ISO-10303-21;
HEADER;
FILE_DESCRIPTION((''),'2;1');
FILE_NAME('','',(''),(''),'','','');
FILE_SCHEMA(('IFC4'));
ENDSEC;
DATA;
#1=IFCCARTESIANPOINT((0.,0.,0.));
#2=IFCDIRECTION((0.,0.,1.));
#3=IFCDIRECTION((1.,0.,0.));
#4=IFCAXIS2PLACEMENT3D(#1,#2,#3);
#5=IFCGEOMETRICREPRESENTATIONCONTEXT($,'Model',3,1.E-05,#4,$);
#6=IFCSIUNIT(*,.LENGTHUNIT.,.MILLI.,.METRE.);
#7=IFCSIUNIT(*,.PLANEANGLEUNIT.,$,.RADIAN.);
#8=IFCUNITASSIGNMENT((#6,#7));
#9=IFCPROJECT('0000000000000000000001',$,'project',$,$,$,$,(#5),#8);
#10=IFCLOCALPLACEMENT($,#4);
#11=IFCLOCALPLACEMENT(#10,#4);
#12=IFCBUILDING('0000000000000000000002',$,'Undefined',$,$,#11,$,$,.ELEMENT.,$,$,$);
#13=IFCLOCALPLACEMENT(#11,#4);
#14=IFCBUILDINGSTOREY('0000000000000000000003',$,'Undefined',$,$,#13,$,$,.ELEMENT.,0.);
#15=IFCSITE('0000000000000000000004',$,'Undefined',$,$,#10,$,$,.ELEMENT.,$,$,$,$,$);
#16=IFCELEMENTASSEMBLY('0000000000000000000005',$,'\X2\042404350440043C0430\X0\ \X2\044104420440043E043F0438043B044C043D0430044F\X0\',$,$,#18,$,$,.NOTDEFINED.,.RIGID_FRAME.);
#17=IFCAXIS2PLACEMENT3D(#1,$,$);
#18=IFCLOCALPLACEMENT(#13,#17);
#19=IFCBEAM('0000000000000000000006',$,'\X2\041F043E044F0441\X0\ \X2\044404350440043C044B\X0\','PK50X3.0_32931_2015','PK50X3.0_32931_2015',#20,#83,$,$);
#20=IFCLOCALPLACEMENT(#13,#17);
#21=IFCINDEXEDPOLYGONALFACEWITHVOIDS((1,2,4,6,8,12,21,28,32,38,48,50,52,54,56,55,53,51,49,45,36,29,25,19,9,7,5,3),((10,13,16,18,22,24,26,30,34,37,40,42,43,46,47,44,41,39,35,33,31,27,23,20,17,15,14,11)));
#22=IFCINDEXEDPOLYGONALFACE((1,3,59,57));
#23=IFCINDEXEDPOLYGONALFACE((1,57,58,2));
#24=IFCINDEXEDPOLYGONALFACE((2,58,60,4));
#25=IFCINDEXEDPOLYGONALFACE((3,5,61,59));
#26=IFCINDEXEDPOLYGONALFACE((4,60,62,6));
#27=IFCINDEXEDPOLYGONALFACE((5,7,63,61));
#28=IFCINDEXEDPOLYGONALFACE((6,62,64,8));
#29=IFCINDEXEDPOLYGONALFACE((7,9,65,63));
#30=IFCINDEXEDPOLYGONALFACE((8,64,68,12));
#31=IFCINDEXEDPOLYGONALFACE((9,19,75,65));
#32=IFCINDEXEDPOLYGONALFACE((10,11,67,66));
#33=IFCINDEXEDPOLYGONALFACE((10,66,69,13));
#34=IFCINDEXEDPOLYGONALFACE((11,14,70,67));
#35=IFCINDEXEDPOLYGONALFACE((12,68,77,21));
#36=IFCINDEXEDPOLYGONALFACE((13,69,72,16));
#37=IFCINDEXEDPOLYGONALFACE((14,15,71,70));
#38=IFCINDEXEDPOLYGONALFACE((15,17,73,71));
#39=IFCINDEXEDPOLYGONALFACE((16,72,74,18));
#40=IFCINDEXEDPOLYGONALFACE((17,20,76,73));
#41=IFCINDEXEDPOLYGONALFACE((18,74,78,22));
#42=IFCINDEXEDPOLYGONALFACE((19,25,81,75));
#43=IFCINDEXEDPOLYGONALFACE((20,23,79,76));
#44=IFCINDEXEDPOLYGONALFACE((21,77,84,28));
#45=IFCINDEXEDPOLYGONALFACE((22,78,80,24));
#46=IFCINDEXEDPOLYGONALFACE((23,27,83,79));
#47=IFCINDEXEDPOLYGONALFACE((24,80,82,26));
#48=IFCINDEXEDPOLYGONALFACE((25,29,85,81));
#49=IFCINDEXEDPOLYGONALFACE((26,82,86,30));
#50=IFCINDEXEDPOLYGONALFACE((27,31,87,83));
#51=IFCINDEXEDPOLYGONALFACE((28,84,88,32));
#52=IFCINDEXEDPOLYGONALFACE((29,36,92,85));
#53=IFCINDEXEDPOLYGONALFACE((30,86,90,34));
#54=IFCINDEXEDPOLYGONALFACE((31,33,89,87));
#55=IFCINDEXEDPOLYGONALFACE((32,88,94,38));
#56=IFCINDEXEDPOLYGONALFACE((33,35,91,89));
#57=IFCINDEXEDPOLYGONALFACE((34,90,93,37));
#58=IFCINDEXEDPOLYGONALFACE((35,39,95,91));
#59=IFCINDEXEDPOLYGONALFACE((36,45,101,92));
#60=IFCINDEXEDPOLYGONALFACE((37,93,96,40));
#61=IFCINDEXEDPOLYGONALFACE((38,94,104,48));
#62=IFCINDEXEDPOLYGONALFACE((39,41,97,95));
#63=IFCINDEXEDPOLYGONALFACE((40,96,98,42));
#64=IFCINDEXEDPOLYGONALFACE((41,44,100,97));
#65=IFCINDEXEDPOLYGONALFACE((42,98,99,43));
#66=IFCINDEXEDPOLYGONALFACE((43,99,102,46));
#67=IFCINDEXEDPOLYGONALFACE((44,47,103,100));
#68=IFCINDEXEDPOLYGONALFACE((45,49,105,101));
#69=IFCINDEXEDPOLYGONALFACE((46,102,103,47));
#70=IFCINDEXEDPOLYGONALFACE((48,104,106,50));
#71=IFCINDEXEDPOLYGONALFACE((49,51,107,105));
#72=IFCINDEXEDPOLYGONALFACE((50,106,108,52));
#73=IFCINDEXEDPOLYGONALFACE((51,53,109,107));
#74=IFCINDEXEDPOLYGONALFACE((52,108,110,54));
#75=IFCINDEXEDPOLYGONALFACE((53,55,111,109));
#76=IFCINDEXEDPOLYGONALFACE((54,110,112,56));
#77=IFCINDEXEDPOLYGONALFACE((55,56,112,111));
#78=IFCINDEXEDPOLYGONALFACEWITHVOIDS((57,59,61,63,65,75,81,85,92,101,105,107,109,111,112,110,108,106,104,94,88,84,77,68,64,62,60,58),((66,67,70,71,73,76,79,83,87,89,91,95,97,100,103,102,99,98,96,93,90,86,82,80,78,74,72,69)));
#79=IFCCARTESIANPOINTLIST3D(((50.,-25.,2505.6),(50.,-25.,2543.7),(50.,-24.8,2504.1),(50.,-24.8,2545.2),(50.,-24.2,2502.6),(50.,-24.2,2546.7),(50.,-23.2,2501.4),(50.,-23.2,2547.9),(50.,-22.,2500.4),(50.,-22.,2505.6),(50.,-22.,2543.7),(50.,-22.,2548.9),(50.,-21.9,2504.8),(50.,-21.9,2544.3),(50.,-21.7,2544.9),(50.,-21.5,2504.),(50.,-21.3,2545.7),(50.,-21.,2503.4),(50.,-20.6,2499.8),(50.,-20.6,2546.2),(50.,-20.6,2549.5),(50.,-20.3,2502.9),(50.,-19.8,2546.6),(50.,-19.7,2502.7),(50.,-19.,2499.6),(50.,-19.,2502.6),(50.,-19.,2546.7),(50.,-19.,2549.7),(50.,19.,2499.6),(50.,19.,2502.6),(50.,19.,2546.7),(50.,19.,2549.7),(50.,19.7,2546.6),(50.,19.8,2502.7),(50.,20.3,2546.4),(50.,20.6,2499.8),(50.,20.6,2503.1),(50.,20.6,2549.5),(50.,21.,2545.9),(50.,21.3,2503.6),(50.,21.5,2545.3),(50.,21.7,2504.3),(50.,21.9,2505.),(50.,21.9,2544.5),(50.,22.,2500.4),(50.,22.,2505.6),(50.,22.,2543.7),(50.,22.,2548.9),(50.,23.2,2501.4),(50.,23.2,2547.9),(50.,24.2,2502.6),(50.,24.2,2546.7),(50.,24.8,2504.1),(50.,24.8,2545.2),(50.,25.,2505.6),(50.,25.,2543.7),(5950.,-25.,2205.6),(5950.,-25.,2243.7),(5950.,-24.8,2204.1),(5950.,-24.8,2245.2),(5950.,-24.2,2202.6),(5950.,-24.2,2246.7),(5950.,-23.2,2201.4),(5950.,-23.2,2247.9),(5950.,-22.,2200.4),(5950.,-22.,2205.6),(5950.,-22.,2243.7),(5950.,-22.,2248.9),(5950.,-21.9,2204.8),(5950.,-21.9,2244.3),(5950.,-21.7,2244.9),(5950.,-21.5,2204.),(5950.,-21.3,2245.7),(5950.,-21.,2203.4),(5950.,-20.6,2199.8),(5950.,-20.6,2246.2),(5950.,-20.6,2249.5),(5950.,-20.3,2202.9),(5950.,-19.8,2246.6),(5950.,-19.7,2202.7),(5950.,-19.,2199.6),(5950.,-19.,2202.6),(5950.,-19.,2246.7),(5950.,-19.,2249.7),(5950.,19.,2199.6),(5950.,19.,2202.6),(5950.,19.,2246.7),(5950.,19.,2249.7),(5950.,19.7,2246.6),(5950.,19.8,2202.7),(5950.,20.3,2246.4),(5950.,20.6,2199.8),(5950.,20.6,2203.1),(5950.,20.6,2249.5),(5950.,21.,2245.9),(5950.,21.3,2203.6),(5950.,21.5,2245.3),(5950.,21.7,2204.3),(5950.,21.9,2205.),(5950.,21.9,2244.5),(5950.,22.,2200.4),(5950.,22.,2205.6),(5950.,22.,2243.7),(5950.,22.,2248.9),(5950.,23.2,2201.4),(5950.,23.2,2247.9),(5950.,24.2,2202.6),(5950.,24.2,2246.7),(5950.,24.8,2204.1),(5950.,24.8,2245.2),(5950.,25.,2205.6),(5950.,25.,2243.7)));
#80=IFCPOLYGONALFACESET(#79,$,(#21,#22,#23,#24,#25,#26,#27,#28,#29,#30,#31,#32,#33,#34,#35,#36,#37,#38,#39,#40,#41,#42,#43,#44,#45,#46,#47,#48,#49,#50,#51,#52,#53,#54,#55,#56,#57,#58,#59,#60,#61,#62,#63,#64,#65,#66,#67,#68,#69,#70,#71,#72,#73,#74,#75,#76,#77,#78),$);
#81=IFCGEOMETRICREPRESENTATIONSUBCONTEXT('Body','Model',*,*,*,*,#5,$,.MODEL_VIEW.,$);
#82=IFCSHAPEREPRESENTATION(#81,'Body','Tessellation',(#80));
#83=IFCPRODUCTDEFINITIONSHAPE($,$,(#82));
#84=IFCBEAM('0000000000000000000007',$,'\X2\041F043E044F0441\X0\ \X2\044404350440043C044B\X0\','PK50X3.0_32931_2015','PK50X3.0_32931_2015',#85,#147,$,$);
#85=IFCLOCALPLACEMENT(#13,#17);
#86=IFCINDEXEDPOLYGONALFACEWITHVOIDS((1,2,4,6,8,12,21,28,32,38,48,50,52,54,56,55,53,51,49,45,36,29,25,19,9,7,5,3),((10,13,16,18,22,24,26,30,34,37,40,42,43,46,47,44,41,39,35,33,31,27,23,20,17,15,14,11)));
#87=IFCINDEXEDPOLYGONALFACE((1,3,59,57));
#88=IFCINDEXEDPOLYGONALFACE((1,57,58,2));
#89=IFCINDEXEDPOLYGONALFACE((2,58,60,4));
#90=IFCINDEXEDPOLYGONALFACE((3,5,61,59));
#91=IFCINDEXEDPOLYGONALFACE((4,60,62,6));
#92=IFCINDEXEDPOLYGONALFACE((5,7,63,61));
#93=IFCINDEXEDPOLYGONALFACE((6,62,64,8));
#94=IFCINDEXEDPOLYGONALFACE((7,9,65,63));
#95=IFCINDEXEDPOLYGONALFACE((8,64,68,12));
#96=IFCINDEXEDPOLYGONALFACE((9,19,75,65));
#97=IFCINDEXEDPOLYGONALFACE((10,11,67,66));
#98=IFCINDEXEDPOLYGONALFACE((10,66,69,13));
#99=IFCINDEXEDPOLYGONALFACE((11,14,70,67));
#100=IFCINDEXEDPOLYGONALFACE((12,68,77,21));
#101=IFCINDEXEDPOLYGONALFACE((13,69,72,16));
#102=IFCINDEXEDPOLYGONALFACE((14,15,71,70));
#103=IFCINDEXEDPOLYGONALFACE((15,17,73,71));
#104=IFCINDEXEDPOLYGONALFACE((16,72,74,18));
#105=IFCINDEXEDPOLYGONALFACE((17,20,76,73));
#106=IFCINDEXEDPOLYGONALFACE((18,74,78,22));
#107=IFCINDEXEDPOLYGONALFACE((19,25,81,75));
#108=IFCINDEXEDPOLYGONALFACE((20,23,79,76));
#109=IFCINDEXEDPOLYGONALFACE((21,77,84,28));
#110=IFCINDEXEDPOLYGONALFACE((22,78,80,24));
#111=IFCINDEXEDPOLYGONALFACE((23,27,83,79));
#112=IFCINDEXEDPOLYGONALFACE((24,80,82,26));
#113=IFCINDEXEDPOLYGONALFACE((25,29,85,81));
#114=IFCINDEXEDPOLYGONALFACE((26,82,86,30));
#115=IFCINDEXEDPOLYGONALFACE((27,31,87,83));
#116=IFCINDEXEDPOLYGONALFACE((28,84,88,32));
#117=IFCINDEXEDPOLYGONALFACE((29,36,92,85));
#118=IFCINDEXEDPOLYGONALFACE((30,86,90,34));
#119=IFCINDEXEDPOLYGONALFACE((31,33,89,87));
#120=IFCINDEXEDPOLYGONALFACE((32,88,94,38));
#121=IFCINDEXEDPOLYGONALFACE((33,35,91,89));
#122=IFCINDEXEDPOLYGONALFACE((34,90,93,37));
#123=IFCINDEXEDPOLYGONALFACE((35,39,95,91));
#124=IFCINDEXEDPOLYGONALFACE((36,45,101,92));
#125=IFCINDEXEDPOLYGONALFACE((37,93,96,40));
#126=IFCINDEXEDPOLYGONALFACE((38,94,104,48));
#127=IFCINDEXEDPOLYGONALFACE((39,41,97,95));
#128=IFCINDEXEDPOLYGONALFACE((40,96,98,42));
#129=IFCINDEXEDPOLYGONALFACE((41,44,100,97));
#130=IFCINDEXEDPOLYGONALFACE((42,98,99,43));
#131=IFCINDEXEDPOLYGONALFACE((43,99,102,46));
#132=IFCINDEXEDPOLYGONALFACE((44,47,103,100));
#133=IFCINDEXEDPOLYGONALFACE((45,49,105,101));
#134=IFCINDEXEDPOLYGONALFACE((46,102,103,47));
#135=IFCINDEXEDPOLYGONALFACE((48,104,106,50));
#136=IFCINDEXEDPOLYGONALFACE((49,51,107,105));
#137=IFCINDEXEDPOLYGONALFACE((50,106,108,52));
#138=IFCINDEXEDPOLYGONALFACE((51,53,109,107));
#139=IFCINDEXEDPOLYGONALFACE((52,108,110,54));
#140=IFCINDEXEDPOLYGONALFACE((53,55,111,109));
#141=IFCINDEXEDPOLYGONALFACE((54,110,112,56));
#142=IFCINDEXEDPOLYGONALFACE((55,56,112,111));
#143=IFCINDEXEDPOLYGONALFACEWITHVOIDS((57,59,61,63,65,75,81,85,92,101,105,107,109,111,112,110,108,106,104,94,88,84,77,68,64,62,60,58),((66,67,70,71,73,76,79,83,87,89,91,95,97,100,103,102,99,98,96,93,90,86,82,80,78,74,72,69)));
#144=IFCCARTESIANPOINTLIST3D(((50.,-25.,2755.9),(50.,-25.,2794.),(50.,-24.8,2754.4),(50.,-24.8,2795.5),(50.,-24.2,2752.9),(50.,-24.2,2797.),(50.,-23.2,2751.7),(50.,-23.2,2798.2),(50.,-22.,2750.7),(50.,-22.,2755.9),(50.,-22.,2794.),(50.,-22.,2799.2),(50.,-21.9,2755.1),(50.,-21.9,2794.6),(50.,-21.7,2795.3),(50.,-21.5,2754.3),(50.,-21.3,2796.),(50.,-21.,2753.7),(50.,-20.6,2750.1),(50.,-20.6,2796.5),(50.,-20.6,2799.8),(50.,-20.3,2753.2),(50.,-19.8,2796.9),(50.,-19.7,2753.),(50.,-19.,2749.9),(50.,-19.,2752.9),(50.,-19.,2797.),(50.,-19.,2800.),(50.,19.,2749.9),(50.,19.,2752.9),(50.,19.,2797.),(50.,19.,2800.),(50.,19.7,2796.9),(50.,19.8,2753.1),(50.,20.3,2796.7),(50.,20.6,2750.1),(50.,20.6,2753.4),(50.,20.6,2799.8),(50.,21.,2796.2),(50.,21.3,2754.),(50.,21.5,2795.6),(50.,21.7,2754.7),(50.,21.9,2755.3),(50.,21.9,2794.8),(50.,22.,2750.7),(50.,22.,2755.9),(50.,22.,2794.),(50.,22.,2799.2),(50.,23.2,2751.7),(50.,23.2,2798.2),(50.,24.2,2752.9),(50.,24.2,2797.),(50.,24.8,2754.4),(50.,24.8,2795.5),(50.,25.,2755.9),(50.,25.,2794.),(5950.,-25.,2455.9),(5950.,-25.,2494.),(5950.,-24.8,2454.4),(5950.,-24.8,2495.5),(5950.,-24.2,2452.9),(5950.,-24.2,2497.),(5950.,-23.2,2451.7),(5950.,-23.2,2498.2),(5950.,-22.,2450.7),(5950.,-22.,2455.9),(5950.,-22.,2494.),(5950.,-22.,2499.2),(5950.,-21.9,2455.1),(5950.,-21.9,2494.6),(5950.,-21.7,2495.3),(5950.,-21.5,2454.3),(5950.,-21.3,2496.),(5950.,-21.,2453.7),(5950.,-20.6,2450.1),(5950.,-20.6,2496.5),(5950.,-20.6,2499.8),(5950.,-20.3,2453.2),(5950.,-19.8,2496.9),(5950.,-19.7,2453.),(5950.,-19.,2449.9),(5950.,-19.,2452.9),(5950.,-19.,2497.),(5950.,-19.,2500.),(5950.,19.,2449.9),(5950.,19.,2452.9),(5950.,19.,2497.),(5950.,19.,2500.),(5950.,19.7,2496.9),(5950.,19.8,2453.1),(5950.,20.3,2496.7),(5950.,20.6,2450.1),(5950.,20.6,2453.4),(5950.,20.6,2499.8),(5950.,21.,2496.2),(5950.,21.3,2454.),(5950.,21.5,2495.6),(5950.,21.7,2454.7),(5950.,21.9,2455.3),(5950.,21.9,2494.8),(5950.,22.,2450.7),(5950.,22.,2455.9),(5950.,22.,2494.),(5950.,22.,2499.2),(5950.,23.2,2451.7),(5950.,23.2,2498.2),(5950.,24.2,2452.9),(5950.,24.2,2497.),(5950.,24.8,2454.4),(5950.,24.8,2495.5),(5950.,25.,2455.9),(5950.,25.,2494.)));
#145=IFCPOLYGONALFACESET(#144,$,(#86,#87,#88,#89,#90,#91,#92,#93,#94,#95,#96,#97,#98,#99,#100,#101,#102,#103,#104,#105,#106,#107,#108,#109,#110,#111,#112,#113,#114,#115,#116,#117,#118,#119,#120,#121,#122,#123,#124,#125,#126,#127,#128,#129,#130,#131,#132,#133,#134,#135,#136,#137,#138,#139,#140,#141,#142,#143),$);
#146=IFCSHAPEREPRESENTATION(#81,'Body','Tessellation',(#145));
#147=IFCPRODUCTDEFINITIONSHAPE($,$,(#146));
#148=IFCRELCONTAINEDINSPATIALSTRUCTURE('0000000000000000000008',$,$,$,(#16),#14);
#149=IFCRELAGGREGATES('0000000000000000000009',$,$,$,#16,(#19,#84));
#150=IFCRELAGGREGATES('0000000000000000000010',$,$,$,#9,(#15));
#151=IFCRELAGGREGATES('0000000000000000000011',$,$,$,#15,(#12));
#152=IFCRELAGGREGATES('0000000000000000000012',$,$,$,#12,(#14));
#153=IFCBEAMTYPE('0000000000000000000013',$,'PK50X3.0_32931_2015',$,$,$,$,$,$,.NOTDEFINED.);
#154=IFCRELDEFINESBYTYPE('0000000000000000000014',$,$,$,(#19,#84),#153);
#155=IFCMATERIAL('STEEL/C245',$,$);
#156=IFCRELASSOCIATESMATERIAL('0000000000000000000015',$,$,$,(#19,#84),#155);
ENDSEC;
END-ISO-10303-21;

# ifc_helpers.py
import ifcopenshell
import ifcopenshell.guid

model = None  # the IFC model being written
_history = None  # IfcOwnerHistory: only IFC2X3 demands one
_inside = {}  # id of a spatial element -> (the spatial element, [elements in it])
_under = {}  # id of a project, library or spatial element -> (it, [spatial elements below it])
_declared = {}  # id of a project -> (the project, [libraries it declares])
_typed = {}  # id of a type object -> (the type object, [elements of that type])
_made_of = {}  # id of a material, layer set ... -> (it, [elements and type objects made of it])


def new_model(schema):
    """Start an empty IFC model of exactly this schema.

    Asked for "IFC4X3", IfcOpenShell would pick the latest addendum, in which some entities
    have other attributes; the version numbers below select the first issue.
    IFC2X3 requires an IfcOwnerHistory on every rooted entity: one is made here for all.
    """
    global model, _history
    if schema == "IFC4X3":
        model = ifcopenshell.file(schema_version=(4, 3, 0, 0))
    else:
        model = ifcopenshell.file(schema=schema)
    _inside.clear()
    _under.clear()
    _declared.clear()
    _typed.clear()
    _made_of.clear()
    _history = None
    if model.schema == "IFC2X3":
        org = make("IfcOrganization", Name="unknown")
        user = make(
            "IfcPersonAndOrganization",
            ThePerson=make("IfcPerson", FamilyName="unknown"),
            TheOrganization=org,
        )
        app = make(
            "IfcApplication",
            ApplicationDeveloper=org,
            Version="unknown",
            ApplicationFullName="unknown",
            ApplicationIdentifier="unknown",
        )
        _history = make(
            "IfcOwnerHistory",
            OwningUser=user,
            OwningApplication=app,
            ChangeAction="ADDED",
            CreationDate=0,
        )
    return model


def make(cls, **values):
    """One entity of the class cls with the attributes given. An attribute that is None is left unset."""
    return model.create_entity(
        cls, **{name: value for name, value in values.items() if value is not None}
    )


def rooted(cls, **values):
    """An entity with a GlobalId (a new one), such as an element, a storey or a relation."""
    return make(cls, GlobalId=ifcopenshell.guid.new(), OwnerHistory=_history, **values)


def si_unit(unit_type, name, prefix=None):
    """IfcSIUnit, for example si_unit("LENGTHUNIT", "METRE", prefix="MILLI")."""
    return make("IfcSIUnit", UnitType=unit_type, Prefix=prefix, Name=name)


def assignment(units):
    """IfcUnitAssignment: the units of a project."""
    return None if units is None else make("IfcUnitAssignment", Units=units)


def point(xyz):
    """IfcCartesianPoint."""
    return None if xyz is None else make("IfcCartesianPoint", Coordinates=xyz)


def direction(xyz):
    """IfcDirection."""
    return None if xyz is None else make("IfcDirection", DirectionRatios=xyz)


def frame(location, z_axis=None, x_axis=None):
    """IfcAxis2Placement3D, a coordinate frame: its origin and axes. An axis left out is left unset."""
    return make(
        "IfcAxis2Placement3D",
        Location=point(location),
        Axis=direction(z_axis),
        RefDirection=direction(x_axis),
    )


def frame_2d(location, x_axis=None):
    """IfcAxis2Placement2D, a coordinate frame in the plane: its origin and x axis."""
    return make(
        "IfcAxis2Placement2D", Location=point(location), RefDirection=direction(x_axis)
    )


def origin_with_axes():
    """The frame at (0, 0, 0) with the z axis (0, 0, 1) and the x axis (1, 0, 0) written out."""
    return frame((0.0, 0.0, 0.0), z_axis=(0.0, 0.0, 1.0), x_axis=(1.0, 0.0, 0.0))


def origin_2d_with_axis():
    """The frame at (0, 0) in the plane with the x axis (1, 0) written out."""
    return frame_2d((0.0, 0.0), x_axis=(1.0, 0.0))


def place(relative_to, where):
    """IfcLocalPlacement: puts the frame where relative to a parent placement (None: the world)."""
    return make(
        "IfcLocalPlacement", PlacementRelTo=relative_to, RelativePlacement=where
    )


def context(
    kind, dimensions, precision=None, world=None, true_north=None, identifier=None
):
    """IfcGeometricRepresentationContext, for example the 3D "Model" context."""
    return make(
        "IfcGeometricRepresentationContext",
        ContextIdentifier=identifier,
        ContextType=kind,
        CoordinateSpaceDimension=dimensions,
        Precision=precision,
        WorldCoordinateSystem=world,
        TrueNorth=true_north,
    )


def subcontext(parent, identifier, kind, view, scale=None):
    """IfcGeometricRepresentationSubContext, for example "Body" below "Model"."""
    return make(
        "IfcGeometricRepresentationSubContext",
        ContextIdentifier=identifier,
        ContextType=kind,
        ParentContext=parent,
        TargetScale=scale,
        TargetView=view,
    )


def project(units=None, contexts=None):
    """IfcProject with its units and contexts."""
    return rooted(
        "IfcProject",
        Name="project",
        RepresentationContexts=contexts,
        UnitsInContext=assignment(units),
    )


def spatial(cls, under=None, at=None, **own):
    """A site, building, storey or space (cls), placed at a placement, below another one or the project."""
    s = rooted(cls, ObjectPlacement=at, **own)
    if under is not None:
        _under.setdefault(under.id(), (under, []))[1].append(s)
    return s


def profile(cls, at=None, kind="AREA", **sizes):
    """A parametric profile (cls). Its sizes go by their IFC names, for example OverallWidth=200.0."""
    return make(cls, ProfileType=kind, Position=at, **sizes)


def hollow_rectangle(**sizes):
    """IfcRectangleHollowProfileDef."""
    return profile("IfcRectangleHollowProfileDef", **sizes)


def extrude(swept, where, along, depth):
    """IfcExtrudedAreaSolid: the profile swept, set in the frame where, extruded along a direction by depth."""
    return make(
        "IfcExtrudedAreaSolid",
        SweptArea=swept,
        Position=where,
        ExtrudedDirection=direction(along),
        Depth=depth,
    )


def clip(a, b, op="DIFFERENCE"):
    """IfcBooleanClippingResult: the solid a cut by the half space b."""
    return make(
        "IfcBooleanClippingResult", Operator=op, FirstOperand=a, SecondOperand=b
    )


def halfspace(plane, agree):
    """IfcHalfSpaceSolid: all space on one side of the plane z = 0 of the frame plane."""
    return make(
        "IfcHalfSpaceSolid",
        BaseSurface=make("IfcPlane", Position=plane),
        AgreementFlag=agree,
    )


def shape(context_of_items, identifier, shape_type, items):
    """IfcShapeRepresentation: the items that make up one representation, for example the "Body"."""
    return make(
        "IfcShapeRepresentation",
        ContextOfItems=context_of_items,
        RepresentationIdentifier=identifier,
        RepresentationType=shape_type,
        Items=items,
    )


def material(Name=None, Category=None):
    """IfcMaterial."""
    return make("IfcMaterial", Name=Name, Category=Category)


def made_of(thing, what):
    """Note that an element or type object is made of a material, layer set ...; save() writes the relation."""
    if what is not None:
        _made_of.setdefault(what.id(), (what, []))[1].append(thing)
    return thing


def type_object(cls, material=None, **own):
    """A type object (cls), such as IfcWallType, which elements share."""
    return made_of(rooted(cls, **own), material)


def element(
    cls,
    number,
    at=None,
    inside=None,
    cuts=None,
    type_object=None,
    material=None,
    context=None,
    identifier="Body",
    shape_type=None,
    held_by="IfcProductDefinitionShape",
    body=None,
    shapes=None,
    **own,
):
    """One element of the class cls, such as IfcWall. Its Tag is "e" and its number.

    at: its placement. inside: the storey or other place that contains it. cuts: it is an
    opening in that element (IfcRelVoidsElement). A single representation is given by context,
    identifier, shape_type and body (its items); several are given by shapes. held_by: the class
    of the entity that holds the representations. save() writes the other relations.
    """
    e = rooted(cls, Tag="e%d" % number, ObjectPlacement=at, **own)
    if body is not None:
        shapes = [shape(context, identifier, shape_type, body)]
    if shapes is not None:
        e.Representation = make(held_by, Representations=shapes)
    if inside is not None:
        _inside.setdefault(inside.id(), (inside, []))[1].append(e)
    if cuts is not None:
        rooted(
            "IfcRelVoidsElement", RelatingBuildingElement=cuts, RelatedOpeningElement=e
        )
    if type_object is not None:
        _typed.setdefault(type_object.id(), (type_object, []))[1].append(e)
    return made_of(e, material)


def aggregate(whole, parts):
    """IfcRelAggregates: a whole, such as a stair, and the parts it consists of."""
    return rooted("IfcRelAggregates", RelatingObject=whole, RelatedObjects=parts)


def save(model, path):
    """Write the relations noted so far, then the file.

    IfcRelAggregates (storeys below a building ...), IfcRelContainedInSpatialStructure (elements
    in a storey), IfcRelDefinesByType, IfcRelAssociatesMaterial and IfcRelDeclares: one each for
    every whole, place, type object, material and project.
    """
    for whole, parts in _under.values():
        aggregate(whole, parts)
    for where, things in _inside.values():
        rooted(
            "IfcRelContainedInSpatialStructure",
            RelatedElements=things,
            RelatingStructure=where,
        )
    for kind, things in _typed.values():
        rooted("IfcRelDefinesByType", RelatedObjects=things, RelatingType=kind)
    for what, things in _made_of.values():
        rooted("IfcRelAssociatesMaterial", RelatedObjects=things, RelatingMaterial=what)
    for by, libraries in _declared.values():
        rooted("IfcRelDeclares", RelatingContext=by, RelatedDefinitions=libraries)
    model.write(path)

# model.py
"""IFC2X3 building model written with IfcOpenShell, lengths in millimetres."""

from ifc_helpers import new_model, si_unit, frame, origin_with_axes, origin_2d_with_axis, place, context, subcontext, project, spatial, hollow_rectangle, extrude, clip, halfspace, material, type_object, element, aggregate, save


model = new_model("IFC2X3")

# Units and contexts
model_context = context("Model", 3, precision=1e-05, world=origin_with_axes())
body_context = subcontext(model_context, "Body", "Model", "MODEL_VIEW")
ifc_project = project(units=[si_unit("LENGTHUNIT", "METRE", prefix="MILLI"), si_unit("PLANEANGLEUNIT", "RADIAN")], contexts=[model_context])

# Site, building, storey
site_placement = place(None, origin_with_axes())
site = spatial("IfcSite", under=ifc_project, at=site_placement, Name="Undefined", CompositionType="ELEMENT")
building_placement = place(site_placement, origin_with_axes())
building = spatial("IfcBuilding", under=site, at=building_placement, Name="Undefined", CompositionType="ELEMENT")
storey_placement = place(building_placement, origin_with_axes())
storey = spatial("IfcBuildingStorey", under=building, at=storey_placement, Name="Undefined", CompositionType="ELEMENT", Elevation=0.0)

# Shared definitions
ifc_material_1 = material(Name="STEEL/C245")

# Element assembly
assembly_1_placement = place(storey_placement, origin_with_axes())
assembly_1 = element("IfcElementAssembly", 1, at=assembly_1_placement, inside=storey, Name="Ферма стропильная", AssemblyPlace="NOTDEFINED", PredefinedType="RIGID_FRAME")

# Beams
beam_type_1 = type_object("IfcBeamType", Name="PK50X3.0_32931_2015", PredefinedType="NOTDEFINED")
beam_1_placement = place(assembly_1_placement, frame((36.0, 0.0, 2525.4), z_axis=(0.050782, 0.0, 0.99871), x_axis=(0.99871, 0.0, -0.050782)))
beam_1 = element("IfcBeam", 2, at=beam_1_placement, type_object=beam_type_1, material=ifc_material_1, Name="Пояс фермы", Description="PK50X3.0_32931_2015", ObjectType="PK50X3.0_32931_2015", context=body_context, shape_type="Clipping", body=[
    clip(clip(extrude(hollow_rectangle(XDim=50.0, YDim=50.0, WallThickness=3.0, InnerFilletRadius=3.0, OuterFilletRadius=6.0, at=origin_2d_with_axis()), frame((5924.2, 0.0, 0.0), z_axis=(-1.0, 0.0, 0.0), x_axis=(0.0, -1.0, 0.0)), (0.0, 0.0, 1.0), 5912.8), halfspace(frame((5907.6, 0.0, 275.0), z_axis=(0.99871, 0.0, 0.050782), x_axis=(0.0, -1.0, 0.0)), False)), halfspace(frame((0.0, 0.0, 275.0), z_axis=(0.99871, 0.0, 0.050782), x_axis=(0.0, -1.0, 0.0)), True)),
])
beam_2_placement = place(assembly_1_placement, frame((48.7, 0.0, 2775.0), z_axis=(0.050782, 0.0, 0.99871), x_axis=(0.99871, 0.0, -0.050782)))
beam_2 = element("IfcBeam", 3, at=beam_2_placement, type_object=beam_type_1, material=ifc_material_1, Name="Пояс фермы", Description="PK50X3.0_32931_2015", ObjectType="PK50X3.0_32931_2015", context=body_context, shape_type="Clipping", body=[
    clip(clip(extrude(hollow_rectangle(XDim=50.0, YDim=50.0, WallThickness=3.0, InnerFilletRadius=3.0, OuterFilletRadius=6.0, at=origin_2d_with_axis()), frame((5911.5, 0.0, 0.0), z_axis=(-1.0, 0.0, 0.0), x_axis=(0.0, -1.0, 0.0)), (0.0, 0.0, 1.0), 5912.8), halfspace(frame((5907.6, 0.0, 25.0), z_axis=(0.99871, 0.0, 0.050782), x_axis=(0.0, -1.0, 0.0)), False)), halfspace(frame((0.0, 0.0, 25.0), z_axis=(0.99871, 0.0, 0.050782), x_axis=(0.0, -1.0, 0.0)), True)),
])
aggregate(assembly_1, [beam_1, beam_2])

save(model, "model.ifc")
